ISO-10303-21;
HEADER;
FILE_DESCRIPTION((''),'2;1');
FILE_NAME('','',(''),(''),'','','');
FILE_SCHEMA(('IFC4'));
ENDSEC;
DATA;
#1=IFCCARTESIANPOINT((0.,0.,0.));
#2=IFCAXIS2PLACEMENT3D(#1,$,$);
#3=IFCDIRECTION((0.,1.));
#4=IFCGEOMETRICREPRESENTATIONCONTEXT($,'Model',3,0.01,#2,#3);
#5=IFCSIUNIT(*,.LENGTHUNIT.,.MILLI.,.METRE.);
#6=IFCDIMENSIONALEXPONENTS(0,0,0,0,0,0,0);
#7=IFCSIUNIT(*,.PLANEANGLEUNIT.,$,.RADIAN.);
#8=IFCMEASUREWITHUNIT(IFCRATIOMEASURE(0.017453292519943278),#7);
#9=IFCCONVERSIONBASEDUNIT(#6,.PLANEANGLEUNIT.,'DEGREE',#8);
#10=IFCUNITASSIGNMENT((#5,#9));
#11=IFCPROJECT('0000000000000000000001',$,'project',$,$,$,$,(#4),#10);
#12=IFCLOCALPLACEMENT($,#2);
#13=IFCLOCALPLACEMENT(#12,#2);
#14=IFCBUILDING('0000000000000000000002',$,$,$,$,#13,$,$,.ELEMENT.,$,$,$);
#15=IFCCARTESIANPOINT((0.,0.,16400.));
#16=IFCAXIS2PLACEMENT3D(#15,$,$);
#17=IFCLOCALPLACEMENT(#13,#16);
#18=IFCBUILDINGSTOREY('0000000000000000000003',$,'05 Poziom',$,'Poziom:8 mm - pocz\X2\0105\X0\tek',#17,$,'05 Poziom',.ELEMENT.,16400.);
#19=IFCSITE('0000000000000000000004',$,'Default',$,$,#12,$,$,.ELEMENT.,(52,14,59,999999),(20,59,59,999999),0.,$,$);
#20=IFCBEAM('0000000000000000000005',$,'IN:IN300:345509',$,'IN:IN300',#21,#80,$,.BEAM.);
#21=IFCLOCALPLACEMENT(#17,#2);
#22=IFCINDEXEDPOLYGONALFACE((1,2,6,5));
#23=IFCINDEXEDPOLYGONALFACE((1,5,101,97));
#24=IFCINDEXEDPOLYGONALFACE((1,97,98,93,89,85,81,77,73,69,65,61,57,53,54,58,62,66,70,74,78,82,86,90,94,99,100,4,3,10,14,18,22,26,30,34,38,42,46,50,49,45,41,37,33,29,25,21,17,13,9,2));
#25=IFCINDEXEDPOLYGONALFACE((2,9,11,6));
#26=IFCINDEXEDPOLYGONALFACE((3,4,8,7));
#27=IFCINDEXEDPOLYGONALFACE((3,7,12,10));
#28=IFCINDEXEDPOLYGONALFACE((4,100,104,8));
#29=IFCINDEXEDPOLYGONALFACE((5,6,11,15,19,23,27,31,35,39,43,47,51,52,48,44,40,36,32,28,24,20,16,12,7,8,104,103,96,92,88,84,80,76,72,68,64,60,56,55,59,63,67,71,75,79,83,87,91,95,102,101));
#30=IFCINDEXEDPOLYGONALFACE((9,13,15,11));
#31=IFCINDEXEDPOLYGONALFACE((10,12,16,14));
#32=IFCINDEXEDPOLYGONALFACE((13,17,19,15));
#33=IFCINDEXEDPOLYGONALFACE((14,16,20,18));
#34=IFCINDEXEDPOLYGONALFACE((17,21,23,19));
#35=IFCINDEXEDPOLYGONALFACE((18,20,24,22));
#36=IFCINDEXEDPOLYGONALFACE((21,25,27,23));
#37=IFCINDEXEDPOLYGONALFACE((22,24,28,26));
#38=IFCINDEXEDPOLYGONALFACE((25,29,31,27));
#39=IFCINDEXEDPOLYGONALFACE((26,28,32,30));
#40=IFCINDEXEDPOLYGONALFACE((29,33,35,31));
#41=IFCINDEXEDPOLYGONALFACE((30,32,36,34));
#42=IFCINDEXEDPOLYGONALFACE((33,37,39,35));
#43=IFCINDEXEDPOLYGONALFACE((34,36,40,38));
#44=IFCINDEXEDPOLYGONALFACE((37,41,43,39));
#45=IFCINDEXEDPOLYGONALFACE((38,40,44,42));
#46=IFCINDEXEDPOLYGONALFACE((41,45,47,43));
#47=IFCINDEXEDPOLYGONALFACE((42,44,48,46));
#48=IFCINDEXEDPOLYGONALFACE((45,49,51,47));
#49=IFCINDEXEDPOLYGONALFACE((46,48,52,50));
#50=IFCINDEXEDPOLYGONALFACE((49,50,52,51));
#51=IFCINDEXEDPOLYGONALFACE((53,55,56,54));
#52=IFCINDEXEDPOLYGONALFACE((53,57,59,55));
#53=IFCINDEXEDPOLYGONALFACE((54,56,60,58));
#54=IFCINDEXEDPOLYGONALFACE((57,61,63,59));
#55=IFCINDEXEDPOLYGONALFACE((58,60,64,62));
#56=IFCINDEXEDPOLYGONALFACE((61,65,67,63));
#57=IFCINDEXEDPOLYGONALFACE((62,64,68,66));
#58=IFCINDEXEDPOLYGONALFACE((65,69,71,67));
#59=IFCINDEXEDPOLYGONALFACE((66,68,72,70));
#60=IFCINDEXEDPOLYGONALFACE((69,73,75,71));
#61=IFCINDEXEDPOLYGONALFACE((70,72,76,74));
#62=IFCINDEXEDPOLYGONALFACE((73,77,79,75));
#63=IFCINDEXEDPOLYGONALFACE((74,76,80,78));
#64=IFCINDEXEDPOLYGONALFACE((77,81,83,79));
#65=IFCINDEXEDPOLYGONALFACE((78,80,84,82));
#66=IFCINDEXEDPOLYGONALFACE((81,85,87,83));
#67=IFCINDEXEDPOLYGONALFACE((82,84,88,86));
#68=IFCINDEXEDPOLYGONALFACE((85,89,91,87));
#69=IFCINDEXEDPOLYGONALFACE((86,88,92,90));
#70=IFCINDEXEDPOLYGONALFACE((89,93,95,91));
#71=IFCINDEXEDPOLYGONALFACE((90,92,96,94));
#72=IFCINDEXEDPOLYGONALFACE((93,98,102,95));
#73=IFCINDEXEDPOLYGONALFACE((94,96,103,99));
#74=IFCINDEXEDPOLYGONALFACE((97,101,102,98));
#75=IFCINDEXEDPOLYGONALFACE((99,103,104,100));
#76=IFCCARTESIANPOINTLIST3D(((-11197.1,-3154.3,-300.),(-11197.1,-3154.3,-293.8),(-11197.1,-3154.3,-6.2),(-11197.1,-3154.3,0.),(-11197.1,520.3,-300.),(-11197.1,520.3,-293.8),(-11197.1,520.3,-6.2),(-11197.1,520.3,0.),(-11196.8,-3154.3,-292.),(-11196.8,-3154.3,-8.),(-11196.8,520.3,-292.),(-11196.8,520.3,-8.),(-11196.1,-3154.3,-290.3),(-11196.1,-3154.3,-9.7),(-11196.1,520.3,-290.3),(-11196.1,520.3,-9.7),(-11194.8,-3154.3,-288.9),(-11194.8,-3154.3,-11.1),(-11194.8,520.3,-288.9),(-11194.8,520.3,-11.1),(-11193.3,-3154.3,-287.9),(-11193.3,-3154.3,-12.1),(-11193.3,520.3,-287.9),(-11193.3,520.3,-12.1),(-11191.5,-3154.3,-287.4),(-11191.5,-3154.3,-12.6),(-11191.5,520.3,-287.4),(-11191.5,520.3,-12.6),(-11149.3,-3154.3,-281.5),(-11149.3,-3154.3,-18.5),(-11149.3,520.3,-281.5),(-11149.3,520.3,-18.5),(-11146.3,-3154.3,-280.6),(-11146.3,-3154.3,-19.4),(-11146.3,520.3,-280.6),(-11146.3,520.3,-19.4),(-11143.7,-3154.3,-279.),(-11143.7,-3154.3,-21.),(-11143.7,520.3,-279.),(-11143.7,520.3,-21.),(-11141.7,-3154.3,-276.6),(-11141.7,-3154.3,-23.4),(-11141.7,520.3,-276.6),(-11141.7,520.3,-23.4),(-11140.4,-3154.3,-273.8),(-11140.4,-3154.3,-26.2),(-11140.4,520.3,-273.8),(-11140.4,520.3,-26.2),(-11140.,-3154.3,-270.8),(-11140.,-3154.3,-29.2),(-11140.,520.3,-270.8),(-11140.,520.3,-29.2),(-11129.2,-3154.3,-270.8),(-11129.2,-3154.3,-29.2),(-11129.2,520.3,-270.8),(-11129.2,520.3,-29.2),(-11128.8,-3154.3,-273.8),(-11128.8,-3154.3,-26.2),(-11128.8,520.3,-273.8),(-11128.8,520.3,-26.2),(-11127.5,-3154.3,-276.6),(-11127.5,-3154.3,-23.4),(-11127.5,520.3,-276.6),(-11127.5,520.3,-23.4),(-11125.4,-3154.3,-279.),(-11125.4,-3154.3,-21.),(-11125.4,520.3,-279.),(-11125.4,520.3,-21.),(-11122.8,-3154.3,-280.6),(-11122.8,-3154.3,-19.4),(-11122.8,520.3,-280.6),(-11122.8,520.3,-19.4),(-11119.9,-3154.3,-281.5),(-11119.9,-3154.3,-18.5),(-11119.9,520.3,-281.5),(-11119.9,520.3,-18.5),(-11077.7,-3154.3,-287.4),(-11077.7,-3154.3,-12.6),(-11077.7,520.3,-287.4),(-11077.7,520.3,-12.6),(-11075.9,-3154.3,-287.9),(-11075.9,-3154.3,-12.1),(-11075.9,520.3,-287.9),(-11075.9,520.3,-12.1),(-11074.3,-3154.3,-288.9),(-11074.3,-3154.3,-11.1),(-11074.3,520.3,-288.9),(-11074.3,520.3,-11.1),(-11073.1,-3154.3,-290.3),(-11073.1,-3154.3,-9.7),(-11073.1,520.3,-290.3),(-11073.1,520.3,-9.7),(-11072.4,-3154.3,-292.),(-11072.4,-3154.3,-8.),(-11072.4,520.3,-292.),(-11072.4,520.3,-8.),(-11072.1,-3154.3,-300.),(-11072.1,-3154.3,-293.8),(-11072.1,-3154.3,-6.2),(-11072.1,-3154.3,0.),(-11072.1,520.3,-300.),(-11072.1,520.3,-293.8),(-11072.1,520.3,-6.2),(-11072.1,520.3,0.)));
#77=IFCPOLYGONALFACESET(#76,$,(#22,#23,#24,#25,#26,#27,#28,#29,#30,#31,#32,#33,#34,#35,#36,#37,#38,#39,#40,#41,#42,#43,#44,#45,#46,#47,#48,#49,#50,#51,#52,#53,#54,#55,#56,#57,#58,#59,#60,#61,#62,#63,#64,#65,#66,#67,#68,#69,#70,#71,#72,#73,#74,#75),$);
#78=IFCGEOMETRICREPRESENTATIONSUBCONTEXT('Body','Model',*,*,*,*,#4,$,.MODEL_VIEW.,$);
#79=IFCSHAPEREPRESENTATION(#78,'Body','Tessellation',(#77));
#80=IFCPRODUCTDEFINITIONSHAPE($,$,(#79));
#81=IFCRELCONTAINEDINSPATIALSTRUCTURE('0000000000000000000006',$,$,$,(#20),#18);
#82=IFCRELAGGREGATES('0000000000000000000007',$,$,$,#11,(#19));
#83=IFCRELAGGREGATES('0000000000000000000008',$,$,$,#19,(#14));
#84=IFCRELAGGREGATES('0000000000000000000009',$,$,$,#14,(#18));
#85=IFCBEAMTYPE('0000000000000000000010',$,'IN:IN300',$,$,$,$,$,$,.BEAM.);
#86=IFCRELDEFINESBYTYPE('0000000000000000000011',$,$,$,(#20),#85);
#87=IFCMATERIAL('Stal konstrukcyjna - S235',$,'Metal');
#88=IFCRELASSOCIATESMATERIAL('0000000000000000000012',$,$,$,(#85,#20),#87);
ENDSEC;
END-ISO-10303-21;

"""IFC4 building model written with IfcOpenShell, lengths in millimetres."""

from ifc_helpers import new_model, entity, si_unit, converted_unit, direction, frame, origin, place, context, subcontext, project, spatial, line, arc, indexed_curve, outline, extrude, source, transform, mapped, material, type_object, type_shapes, element, save


model = new_model("IFC4")

# Units and contexts
model_context = context("Model", 3, precision=0.01, world=origin(), true_north=direction((0.0, 1.0)))
body_context = subcontext(model_context, "Body", "Model", "MODEL_VIEW")
ifc_project = project(units=[si_unit("LENGTHUNIT", "METRE", prefix="MILLI"), converted_unit("PLANEANGLEUNIT", "DEGREE", entity("IfcRatioMeasure", 0.017453292519943278), si_unit("PLANEANGLEUNIT", "RADIAN"), dimensions=[0, 0, 0, 0, 0, 0, 0])], contexts=[model_context])

# Site, building, storey
site_placement = place(None, origin())
site = spatial("IfcSite", under=ifc_project, at=site_placement, Name="Default", CompositionType="ELEMENT", RefLatitude=(52, 14, 59, 999999), RefLongitude=(20, 59, 59, 999999), RefElevation=0.0)
building_placement = place(site_placement, origin())
building = spatial("IfcBuilding", under=site, at=building_placement, CompositionType="ELEMENT")
storey_placement = place(building_placement, frame((0.0, 0.0, 16400.0)))
storey = spatial("IfcBuildingStorey", under=building, at=storey_placement, Name="05 Poziom", ObjectType="Poziom:8 mm - początek", LongName="05 Poziom", CompositionType="ELEMENT", Elevation=16400.0)

# Shared definitions
ifc_material = material(Name="Stal konstrukcyjna - S235", Category="Metal")

# Beam
beam_type_1 = type_object("IfcBeamType", Name="IN:IN300", PredefinedType="BEAM", material=ifc_material)
shared_shape_1 = source(origin(), body_context, "Body", "SweptSolid", [
    extrude(outline(indexed_curve([(143.8, -62.5), (150.0, -62.5), (150.0, 62.5), (143.8, 62.5), (139.6, 60.9), (137.4, 56.9), (131.5, 14.7), (127.9, 8.1), (120.8, 5.4), (-120.8, 5.4), (-127.9, 8.1), (-131.5, 14.7), (-137.4, 56.9), (-139.6, 60.9), (-143.8, 62.5), (-150.0, 62.5), (-150.0, -62.5), (-143.8, -62.5), (-139.6, -60.9), (-137.4, -56.9), (-131.5, -14.7), (-127.9, -8.1), (-120.8, -5.4), (120.8, -5.4), (127.9, -8.1), (131.5, -14.7), (137.4, -56.9), (139.6, -60.9)], segments=[line(1, 2, 3, 4), arc(4, 5, 6), line(6, 7), arc(7, 8, 9), line(9, 10), arc(10, 11, 12), line(12, 13), arc(13, 14, 15), line(15, 16, 17, 18), arc(18, 19, 20), line(20, 21), arc(21, 22, 23), line(23, 24), arc(24, 25, 26), line(26, 27), arc(27, 28, 1)], self_intersect=False)), frame((-1837.3, 0.0, 0.0), z_axis=(1.0, 0.0, 0.0), x_axis=(0.0, 0.0, -1.0)), (0.0, 0.0, 1.0), 3674.6),
])
type_shapes(beam_type_1, [shared_shape_1])
for number, where, z_axis, x_axis, name in (
    (1, (-11134.6, -1317.0, -150.0), (0.0, 0.0, 1.0), (0.0, -1.0, 0.0), "IN:IN300:345509"),
):
    element("IfcBeam", number, at=place(storey_placement, frame(where, z_axis=z_axis, x_axis=x_axis)), inside=storey, type_object=beam_type_1, material=ifc_material, Name=name, ObjectType="IN:IN300", PredefinedType="BEAM", context=body_context, shape_type="MappedRepresentation", body=[
        mapped(shared_shape_1, transform((0.0, 0.0, 0.0), scale=1.0)),
    ])

save(model, "model.ifc")
